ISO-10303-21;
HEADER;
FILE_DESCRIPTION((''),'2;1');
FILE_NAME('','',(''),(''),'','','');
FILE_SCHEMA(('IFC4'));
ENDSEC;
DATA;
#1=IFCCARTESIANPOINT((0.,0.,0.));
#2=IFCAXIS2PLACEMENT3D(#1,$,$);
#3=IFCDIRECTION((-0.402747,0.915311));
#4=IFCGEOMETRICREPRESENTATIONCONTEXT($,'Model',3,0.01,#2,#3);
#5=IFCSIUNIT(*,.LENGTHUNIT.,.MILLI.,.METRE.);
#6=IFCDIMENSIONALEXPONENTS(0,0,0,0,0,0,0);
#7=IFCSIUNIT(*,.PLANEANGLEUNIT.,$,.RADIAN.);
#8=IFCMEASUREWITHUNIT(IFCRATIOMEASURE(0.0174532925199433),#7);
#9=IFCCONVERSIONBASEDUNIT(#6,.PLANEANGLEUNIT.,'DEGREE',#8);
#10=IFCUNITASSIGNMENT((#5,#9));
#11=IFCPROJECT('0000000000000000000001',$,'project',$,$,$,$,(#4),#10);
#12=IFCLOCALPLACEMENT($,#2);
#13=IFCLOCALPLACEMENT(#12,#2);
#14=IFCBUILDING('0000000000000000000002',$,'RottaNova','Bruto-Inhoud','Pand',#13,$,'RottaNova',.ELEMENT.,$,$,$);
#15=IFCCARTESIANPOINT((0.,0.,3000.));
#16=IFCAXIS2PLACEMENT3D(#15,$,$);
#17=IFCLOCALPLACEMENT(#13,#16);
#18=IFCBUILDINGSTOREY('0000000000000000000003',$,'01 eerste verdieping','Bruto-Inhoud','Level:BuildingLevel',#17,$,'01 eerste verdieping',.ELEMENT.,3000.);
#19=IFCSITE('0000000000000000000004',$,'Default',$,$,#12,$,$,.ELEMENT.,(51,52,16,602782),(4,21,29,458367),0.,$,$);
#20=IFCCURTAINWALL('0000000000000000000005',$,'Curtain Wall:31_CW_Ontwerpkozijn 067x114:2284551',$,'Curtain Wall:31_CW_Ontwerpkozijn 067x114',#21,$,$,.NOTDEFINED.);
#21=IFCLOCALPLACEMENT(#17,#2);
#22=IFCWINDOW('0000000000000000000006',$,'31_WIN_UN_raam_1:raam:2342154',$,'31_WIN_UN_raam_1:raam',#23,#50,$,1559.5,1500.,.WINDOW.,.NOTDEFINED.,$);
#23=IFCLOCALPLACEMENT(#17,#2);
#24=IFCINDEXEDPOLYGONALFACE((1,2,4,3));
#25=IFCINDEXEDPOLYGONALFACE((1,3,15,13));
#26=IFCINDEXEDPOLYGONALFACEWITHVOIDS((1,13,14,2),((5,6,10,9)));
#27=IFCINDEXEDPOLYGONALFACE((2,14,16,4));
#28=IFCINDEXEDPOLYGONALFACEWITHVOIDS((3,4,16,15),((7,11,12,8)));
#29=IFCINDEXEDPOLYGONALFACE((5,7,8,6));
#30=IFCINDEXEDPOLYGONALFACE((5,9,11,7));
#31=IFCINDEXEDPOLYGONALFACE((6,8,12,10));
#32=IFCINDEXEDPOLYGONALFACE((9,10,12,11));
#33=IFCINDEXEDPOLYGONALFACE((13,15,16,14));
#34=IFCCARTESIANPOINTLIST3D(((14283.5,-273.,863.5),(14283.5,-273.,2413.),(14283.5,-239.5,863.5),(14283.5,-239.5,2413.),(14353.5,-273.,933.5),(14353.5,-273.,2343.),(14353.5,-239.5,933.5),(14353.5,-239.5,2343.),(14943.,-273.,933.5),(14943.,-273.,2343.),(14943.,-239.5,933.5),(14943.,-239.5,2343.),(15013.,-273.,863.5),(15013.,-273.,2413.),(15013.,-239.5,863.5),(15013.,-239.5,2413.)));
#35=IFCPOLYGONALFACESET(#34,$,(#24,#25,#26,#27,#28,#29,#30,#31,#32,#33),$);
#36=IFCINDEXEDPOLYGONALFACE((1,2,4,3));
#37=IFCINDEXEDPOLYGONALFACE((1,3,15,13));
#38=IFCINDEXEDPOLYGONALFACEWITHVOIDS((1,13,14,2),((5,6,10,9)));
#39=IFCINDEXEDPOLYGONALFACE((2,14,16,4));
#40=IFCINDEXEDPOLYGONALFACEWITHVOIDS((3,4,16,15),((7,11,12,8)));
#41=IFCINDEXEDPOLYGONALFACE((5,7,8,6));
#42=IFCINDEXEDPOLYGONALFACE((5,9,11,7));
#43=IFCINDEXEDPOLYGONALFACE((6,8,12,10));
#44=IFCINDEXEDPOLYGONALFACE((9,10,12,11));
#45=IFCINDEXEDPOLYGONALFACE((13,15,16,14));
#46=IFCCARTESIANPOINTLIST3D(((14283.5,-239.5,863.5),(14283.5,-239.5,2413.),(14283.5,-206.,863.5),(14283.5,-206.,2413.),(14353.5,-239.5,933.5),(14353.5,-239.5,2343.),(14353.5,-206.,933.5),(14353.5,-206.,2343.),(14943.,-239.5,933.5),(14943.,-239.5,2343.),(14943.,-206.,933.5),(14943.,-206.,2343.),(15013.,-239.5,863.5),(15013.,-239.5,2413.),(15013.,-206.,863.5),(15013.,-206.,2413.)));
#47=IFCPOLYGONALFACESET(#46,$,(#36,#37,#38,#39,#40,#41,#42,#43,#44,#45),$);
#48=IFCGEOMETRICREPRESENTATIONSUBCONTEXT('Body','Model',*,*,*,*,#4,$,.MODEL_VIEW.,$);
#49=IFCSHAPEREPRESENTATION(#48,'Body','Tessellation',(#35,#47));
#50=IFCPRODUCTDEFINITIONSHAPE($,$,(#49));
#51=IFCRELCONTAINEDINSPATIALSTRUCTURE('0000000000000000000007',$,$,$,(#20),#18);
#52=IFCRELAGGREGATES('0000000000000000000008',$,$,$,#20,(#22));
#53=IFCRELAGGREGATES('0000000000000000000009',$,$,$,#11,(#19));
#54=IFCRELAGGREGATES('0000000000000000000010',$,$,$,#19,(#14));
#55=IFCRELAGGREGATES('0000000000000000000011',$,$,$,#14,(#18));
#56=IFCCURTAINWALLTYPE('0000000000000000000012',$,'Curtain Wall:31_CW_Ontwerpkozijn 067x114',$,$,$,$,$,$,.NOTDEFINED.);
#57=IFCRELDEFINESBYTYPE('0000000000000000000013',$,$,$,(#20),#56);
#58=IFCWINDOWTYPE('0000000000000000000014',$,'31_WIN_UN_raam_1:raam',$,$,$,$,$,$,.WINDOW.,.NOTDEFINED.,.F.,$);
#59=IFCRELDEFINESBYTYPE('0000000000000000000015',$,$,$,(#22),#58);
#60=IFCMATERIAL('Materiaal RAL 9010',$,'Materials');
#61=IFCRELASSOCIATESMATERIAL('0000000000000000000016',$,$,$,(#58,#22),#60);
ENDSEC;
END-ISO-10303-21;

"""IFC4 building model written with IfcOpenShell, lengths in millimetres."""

from ifc_helpers import new_model, entity, si_unit, converted_unit, direction, frame, origin, place, context, subcontext, project, spatial, polyline, outline, extrude, source, transform, mapped, material, type_object, type_shapes, element, aggregate, save


model = new_model("IFC4")

# Units and contexts
model_context = context("Model", 3, precision=0.01, world=origin(), true_north=direction((-0.402747, 0.915311)))
body_context = subcontext(model_context, "Body", "Model", "MODEL_VIEW")
ifc_project = project(units=[si_unit("LENGTHUNIT", "METRE", prefix="MILLI"), converted_unit("PLANEANGLEUNIT", "DEGREE", entity("IfcRatioMeasure", 0.0174532925199433), si_unit("PLANEANGLEUNIT", "RADIAN"), dimensions=[0, 0, 0, 0, 0, 0, 0])], contexts=[model_context])

# Site, building, storey
site_placement = place(None, origin())
site = spatial("IfcSite", under=ifc_project, at=site_placement, Name="Default", CompositionType="ELEMENT", RefLatitude=(51, 52, 16, 602782), RefLongitude=(4, 21, 29, 458367), RefElevation=0.0)
building_placement = place(site_placement, origin())
building = spatial("IfcBuilding", under=site, at=building_placement, Name="RottaNova", Description="Bruto-Inhoud", ObjectType="Pand", LongName="RottaNova", CompositionType="ELEMENT")
storey_placement = place(building_placement, frame((0.0, 0.0, 3000.0)))
storey = spatial("IfcBuildingStorey", under=building, at=storey_placement, Name="01 eerste verdieping", Description="Bruto-Inhoud", ObjectType="Level:BuildingLevel", LongName="01 eerste verdieping", CompositionType="ELEMENT", Elevation=3000.0)

# Curtain wall
curtain_wall_type = type_object("IfcCurtainWallType", Name="Curtain Wall:31_CW_Ontwerpkozijn 067x114", PredefinedType="NOTDEFINED")
curtain_wall_1_placement = place(storey_placement, frame((0.0, 0.0, -3000.0)))
curtain_wall_1 = element("IfcCurtainWall", 1, at=curtain_wall_1_placement, inside=storey, type_object=curtain_wall_type, Name="Curtain Wall:31_CW_Ontwerpkozijn 067x114:2284551", ObjectType="Curtain Wall:31_CW_Ontwerpkozijn 067x114", PredefinedType="NOTDEFINED")

# Window
ifc_material_1 = material(Name="Materiaal RAL 9010", Category="Materials")
window_type = type_object("IfcWindowType", Name="31_WIN_UN_raam_1:raam", ParameterTakesPrecedence=False, PartitioningType="NOTDEFINED", PredefinedType="WINDOW", material=ifc_material_1)
shared_shape_1 = source(origin(), body_context, "Body", "SweptSolid", [
    extrude(outline(polyline([(-364.7, -774.7), (364.7, -774.7), (364.7, 774.7), (-364.7, 774.7), (-364.7, -774.7)]), holes=[polyline([(-294.7, 704.7), (294.7, 704.7), (294.7, -704.8), (-294.7, -704.8), (-294.7, 704.7)])]), frame((0.0, 58.5, 774.8), z_axis=(0.0, 1.0, 0.0), x_axis=(1.0, 0.0, 0.0)), (0.0, 0.0, 1.0), 33.5),
    extrude(outline(polyline([(-364.7, -774.7), (364.7, -774.7), (364.7, 774.7), (-364.7, 774.7), (-364.7, -774.7)]), holes=[polyline([(-294.7, 704.7), (294.7, 704.7), (294.7, -704.8), (-294.7, -704.8), (-294.7, 704.7)])]), frame((0.0, 25.0, 774.8), z_axis=(0.0, 1.0, 0.0), x_axis=(1.0, 0.0, 0.0)), (0.0, 0.0, 1.0), 33.5),
])
type_shapes(window_type, [shared_shape_1])
window_placement = place(curtain_wall_1_placement, frame((14648.2, -181.0, 3863.5), z_axis=(0.0, 0.0, 1.0), x_axis=(-1.0, 0.0, 0.0)))
window = element("IfcWindow", 2, at=window_placement, type_object=window_type, material=ifc_material_1, Name="31_WIN_UN_raam_1:raam:2342154", ObjectType="31_WIN_UN_raam_1:raam", OverallHeight=1559.5, OverallWidth=1500.0, PartitioningType="NOTDEFINED", PredefinedType="WINDOW", context=body_context, shape_type="MappedRepresentation", body=[
    mapped(shared_shape_1, transform((0.0, 0.0, 0.0), scale=1.0)),
])
aggregate(curtain_wall_1, [window])

save(model, "model.ifc")
